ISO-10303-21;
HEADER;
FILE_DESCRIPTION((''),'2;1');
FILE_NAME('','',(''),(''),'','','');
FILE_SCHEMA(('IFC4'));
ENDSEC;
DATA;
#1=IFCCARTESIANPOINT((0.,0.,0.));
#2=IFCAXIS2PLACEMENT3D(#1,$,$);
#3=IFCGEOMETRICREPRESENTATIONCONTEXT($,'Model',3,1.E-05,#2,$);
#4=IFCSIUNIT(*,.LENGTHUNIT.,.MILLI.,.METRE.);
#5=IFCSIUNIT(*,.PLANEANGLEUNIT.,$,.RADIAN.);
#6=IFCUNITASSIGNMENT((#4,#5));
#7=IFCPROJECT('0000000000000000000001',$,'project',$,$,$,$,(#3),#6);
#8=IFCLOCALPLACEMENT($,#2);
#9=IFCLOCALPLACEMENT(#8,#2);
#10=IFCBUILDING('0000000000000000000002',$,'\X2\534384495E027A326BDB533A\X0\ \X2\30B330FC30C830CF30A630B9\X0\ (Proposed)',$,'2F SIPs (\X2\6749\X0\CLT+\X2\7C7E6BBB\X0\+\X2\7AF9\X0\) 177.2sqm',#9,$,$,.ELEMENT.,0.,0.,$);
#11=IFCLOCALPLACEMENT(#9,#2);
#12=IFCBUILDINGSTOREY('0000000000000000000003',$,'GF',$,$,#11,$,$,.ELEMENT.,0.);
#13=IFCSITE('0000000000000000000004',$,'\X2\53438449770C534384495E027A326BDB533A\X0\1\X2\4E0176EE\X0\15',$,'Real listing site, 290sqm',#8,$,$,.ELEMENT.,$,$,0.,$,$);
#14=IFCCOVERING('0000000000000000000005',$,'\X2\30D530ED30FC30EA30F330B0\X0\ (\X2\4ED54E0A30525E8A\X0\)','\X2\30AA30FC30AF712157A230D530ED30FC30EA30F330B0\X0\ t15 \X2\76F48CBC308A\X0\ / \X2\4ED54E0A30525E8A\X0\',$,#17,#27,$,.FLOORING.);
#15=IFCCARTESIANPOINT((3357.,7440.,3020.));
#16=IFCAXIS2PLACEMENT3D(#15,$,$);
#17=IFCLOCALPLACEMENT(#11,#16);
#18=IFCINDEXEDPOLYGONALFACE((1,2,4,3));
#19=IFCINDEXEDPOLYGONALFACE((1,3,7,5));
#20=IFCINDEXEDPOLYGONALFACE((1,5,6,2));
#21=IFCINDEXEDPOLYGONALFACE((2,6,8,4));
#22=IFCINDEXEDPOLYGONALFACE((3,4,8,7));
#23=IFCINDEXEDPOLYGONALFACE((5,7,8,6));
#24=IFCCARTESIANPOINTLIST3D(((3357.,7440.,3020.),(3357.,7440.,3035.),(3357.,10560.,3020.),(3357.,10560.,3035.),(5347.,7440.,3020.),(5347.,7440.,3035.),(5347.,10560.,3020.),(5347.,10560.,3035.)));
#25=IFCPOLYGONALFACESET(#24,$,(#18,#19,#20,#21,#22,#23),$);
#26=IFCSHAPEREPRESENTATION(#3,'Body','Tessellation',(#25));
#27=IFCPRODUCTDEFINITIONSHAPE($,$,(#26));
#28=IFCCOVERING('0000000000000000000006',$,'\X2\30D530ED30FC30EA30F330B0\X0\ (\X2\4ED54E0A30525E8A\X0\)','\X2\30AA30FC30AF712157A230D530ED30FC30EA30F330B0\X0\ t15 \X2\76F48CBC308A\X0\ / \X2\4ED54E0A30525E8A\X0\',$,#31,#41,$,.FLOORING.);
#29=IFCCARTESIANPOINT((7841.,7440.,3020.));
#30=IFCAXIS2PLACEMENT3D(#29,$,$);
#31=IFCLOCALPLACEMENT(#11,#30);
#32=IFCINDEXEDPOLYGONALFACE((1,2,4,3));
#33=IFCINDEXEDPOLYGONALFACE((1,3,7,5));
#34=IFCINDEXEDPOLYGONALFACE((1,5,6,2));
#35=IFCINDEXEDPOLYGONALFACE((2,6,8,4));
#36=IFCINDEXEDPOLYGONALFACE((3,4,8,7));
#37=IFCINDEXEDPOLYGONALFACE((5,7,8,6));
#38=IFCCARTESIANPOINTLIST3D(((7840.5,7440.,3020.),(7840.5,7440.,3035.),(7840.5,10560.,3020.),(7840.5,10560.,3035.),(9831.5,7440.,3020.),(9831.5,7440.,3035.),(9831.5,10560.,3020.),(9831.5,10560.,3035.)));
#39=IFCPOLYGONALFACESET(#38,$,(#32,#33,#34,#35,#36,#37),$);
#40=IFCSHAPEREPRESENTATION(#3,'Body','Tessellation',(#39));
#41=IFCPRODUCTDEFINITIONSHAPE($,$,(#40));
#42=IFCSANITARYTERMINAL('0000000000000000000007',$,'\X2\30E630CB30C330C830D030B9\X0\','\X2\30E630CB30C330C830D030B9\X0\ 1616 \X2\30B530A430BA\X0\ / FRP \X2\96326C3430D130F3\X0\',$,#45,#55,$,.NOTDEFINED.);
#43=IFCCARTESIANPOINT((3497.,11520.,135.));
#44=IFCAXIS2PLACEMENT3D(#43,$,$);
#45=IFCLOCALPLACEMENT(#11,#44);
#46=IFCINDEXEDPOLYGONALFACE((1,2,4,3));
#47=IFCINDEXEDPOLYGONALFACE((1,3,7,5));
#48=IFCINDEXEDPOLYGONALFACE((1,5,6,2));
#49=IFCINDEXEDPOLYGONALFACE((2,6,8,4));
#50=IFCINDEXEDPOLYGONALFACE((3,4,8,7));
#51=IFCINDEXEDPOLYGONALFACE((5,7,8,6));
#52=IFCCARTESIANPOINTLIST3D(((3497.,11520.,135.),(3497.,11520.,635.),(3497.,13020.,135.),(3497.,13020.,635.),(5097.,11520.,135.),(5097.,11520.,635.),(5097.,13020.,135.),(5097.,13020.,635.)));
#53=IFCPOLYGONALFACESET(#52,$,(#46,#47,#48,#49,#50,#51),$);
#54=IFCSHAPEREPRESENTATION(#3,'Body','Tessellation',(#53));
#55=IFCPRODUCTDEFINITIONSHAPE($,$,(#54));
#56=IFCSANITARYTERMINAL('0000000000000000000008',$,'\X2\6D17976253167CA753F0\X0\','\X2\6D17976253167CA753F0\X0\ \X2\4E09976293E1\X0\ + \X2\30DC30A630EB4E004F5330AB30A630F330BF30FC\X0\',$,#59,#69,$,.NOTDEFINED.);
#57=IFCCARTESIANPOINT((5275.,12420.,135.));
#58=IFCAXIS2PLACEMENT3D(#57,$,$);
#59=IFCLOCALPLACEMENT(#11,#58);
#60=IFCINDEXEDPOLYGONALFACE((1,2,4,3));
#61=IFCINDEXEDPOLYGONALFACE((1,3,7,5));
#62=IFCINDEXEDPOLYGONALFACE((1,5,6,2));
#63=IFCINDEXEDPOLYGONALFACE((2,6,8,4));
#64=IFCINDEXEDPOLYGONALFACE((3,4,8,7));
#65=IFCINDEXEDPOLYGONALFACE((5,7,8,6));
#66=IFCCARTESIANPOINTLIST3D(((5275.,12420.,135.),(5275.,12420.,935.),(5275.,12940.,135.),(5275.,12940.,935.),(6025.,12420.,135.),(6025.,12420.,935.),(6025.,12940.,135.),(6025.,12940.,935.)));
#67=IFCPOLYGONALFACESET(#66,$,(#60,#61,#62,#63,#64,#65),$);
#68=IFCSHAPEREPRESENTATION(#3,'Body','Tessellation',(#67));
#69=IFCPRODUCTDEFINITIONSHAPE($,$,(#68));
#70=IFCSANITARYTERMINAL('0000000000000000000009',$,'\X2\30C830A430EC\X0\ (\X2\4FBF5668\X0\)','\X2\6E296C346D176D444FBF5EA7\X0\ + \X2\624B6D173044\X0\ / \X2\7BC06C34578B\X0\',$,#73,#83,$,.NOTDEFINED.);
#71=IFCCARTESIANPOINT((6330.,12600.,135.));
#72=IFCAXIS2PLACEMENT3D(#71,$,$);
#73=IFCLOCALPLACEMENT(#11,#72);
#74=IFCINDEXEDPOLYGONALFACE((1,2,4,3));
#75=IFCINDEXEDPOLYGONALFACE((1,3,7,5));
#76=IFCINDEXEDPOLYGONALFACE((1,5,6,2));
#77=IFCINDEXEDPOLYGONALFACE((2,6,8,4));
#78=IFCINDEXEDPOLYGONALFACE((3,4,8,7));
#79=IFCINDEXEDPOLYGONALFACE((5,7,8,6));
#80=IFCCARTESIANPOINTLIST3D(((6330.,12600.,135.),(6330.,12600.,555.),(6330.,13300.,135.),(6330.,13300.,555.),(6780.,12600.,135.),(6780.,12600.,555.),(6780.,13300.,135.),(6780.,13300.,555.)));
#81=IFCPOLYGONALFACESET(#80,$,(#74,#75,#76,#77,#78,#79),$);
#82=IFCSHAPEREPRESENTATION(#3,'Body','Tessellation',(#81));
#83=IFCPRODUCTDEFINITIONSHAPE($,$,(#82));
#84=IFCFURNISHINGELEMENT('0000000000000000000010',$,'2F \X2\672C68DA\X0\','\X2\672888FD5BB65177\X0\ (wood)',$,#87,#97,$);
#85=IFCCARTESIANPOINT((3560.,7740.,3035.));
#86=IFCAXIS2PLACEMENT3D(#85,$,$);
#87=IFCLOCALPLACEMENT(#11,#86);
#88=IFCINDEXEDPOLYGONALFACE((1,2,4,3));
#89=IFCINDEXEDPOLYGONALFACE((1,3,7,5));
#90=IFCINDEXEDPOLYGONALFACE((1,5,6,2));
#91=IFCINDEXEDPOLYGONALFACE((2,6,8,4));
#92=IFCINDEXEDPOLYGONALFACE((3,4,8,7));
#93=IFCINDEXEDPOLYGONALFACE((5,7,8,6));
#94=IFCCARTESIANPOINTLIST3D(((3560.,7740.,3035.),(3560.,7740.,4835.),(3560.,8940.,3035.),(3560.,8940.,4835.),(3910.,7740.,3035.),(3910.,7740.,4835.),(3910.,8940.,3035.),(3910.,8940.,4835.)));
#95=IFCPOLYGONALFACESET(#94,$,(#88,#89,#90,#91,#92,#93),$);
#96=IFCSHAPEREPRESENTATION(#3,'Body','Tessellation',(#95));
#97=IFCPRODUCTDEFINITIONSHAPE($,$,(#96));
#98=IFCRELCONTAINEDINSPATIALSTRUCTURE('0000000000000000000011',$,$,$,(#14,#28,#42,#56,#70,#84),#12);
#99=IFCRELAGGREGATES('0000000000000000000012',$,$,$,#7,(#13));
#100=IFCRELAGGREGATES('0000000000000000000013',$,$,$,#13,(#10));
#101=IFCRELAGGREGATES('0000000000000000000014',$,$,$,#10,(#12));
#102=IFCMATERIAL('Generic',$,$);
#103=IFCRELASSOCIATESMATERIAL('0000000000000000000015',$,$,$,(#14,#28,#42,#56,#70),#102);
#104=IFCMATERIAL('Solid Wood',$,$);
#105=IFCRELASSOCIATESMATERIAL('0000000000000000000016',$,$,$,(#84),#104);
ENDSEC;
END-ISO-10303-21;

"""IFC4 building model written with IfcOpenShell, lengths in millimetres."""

from ifc_helpers import new_model, si_unit, frame, frame_2d, origin, place, context, project, spatial, rectangle, extrude, material, element, save


model = new_model("IFC4")

# Units and contexts
model_context = context("Model", 3, precision=1e-05, world=origin())
ifc_project = project(units=[si_unit("LENGTHUNIT", "METRE", prefix="MILLI"), si_unit("PLANEANGLEUNIT", "RADIAN")], contexts=[model_context])

# Site, building, storey
site_placement = place(None, origin())
site = spatial("IfcSite", under=ifc_project, at=site_placement, Name="千葉県千葉市稲毛区1丁目15", ObjectType="Real listing site, 290sqm", CompositionType="ELEMENT", RefElevation=0.0)
building_placement = place(site_placement, origin())
building = spatial("IfcBuilding", under=site, at=building_placement, Name="千葉市稲毛区 コートハウス (Proposed)", ObjectType="2F SIPs (杉CLT+籾殻+竹) 177.2sqm", CompositionType="ELEMENT", ElevationOfRefHeight=0.0, ElevationOfTerrain=0.0)
storey_placement = place(building_placement, origin())
storey = spatial("IfcBuildingStorey", under=building, at=storey_placement, Name="GF", CompositionType="ELEMENT", Elevation=0.0)

# Shared definitions
ifc_material_1 = material(Name="Solid Wood")
ifc_material_2 = material(Name="Generic")

# Coverings
covering_1_placement = place(storey_placement, frame((3357.0, 7440.0, 3020.0)))
element("IfcCovering", 1, at=covering_1_placement, inside=storey, material=ifc_material_2, Name="フローリング (仕上げ床)", Description="オーク無垢フローリング t15 直貼り / 仕上げ床", PredefinedType="FLOORING", context=model_context, shape_type="SweptSolid", body=[
    extrude(rectangle(XDim=1990.0, YDim=3120.0, at=frame_2d((995.0, 1560.0))), frame((3357.0, 7440.0, 3020.0)), (0.0, 0.0, 1.0), 15.0),
])
covering_2_placement = place(storey_placement, frame((7841.0, 7440.0, 3020.0)))
element("IfcCovering", 2, at=covering_2_placement, inside=storey, material=ifc_material_2, Name="フローリング (仕上げ床)", Description="オーク無垢フローリング t15 直貼り / 仕上げ床", PredefinedType="FLOORING", context=model_context, shape_type="SweptSolid", body=[
    extrude(rectangle(XDim=1991.0, YDim=3120.0, at=frame_2d((995.0, 1560.0))), frame((7841.0, 7440.0, 3020.0)), (0.0, 0.0, 1.0), 15.0),
])

# Sanitary terminals
sanitary_terminal_1_placement = place(storey_placement, frame((3497.0, 11520.0, 135.0)))
element("IfcSanitaryTerminal", 3, at=sanitary_terminal_1_placement, inside=storey, material=ifc_material_2, Name="ユニットバス", Description="ユニットバス 1616 サイズ / FRP 防水パン", PredefinedType="NOTDEFINED", context=model_context, shape_type="SweptSolid", body=[
    extrude(rectangle(XDim=1600.0, YDim=1500.0, at=frame_2d((800.0, 750.0))), frame((3497.0, 11520.0, 135.0)), (0.0, 0.0, 1.0), 500.0),
])
sanitary_terminal_2_placement = place(storey_placement, frame((5275.0, 12420.0, 135.0)))
element("IfcSanitaryTerminal", 4, at=sanitary_terminal_2_placement, inside=storey, material=ifc_material_2, Name="洗面化粧台", Description="洗面化粧台 三面鏡 + ボウル一体カウンター", PredefinedType="NOTDEFINED", context=model_context, shape_type="SweptSolid", body=[
    extrude(rectangle(XDim=750.0, YDim=520.0, at=frame_2d((375.0, 260.0))), frame((5275.0, 12420.0, 135.0)), (0.0, 0.0, 1.0), 800.0),
])
sanitary_terminal_3_placement = place(storey_placement, frame((6330.0, 12600.0, 135.0)))
element("IfcSanitaryTerminal", 5, at=sanitary_terminal_3_placement, inside=storey, material=ifc_material_2, Name="トイレ (便器)", Description="温水洗浄便座 + 手洗い / 節水型", PredefinedType="NOTDEFINED", context=model_context, shape_type="SweptSolid", body=[
    extrude(rectangle(XDim=450.0, YDim=700.0, at=frame_2d((225.0, 350.0))), frame((6330.0, 12600.0, 135.0)), (0.0, 0.0, 1.0), 420.0),
])

# Furnishing element
furnishing_placement = place(storey_placement, frame((3560.0, 7740.0, 3035.0)))
element("IfcFurnishingElement", 6, at=furnishing_placement, inside=storey, material=ifc_material_1, Name="2F 本棚", Description="木製家具 (wood)", context=model_context, shape_type="SweptSolid", body=[
    extrude(rectangle(XDim=350.0, YDim=1200.0, at=frame_2d((175.0, 600.0))), frame((3560.0, 7740.0, 3035.0)), (0.0, 0.0, 1.0), 1800.0),
])

save(model, "model.ifc")
